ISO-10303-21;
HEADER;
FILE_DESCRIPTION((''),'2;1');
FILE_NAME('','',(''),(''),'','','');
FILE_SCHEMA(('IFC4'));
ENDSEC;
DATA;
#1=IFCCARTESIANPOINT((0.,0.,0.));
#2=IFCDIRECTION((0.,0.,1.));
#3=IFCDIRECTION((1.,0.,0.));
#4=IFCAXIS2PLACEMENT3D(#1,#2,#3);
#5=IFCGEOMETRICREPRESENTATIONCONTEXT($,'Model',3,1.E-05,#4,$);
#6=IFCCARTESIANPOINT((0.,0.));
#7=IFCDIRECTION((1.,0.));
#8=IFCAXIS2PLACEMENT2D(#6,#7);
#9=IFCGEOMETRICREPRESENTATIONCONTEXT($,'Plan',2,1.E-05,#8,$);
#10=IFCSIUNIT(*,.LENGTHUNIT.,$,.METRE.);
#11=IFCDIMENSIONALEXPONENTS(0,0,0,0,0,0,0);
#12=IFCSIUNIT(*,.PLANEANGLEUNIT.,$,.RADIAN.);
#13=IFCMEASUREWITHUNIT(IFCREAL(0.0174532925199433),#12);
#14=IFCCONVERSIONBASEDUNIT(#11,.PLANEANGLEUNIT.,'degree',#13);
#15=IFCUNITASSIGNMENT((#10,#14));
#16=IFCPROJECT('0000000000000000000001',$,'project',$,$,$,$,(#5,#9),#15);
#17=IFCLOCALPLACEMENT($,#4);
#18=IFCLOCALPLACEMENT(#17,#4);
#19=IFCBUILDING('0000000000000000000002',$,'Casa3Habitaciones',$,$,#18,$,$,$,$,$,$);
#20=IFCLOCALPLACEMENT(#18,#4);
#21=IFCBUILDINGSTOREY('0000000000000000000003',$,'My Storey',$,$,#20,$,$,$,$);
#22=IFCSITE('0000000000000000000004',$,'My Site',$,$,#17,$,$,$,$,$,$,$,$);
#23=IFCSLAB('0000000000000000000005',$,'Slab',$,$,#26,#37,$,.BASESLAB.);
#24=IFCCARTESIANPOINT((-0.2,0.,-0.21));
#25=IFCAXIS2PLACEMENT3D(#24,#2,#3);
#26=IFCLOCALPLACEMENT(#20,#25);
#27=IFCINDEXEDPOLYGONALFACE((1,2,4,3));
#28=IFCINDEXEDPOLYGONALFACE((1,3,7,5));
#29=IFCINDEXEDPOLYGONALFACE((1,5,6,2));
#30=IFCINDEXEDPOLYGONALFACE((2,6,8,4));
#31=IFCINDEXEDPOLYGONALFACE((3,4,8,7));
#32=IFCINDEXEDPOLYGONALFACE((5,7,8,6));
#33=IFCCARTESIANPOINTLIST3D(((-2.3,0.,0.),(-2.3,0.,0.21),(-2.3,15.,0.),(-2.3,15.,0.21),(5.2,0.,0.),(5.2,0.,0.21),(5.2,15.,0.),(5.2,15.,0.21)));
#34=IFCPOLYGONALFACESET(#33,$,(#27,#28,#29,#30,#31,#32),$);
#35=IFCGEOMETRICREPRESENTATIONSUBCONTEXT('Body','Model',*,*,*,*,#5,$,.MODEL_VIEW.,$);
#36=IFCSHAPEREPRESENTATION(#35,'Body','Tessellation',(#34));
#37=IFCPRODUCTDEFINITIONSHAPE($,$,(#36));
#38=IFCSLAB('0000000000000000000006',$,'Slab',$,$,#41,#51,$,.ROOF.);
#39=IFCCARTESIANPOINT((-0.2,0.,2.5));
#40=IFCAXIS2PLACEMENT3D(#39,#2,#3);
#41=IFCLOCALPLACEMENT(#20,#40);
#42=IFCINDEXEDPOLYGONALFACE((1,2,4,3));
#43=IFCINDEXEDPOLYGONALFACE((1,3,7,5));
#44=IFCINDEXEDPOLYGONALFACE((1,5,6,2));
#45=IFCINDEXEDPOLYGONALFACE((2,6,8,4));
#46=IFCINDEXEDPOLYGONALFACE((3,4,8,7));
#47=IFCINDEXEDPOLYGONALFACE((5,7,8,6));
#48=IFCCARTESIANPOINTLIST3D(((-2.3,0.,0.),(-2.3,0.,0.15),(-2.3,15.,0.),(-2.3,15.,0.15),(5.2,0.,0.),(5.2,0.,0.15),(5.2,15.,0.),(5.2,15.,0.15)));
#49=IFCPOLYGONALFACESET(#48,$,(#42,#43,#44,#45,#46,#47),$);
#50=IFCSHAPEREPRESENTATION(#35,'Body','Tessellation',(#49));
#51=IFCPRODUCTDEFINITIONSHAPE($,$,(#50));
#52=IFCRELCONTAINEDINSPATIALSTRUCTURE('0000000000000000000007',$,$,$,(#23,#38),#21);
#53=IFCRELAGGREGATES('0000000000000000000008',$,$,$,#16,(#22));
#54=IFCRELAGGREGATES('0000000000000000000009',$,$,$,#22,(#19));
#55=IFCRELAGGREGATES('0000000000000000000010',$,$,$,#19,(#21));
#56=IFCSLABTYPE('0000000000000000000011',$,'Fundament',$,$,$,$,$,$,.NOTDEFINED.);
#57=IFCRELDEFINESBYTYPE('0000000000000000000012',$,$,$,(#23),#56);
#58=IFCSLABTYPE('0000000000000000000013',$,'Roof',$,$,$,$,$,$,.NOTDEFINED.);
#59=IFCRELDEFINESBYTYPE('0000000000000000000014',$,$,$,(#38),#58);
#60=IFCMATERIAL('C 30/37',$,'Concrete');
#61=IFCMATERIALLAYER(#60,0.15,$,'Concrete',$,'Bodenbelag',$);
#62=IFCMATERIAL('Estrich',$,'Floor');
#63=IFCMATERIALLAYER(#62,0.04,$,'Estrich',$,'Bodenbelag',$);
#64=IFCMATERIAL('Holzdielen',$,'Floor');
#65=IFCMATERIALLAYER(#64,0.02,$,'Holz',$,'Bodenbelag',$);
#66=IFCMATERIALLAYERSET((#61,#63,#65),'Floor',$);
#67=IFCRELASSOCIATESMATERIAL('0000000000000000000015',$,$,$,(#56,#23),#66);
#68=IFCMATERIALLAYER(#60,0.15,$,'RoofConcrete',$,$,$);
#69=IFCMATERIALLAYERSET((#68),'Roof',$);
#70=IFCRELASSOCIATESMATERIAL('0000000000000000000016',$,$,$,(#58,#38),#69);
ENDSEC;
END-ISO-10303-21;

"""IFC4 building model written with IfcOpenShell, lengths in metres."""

from ifc_helpers import new_model, entity, si_unit, converted_unit, frame, origin_with_axes, origin_2d_with_axis, place, context, subcontext, project, spatial, line, indexed_curve, outline, extrude, material, layer, layer_set, layer_usage, type_object, element, save


model = new_model("IFC4")

# Units and contexts
model_context = context("Model", 3, precision=1e-05, world=origin_with_axes())
plan_context = context("Plan", 2, precision=1e-05, world=origin_2d_with_axis())
body_context = subcontext(model_context, "Body", "Model", "MODEL_VIEW")
ifc_project = project(units=[si_unit("LENGTHUNIT", "METRE"), converted_unit("PLANEANGLEUNIT", "degree", entity("IfcReal", 0.0174532925199433), si_unit("PLANEANGLEUNIT", "RADIAN"), dimensions=[0, 0, 0, 0, 0, 0, 0])], contexts=[model_context, plan_context])

# Site, building, storey
site_placement = place(None, origin_with_axes())
site = spatial("IfcSite", under=ifc_project, at=site_placement, Name="My Site")
building_placement = place(site_placement, origin_with_axes())
building = spatial("IfcBuilding", under=site, at=building_placement, Name="Casa3Habitaciones")
storey_placement = place(building_placement, origin_with_axes())
storey = spatial("IfcBuildingStorey", under=building, at=storey_placement, Name="My Storey")

# Slabs
ifc_material_1 = material(Name="C 30/37", Category="Concrete")
ifc_layer_1 = layer(ifc_material_1, 0.15, Name="Concrete", Category="Bodenbelag")
ifc_material_2 = material(Name="Estrich", Category="Floor")
ifc_layer_2 = layer(ifc_material_2, 0.04, Name="Estrich", Category="Bodenbelag")
ifc_material_3 = material(Name="Holzdielen", Category="Floor")
ifc_layer_3 = layer(ifc_material_3, 0.02, Name="Holz", Category="Bodenbelag")
ifc_layer_set_1 = layer_set([ifc_layer_1, ifc_layer_2, ifc_layer_3], Name="Floor")
ifc_layer_usage_1 = layer_usage(ifc_layer_set_1, "AXIS3", "POSITIVE", 0.0)
slab_type_1 = type_object("IfcSlabType", Name="Fundament", PredefinedType="NOTDEFINED", material=ifc_layer_set_1)
slab_1_placement = place(storey_placement, frame((-0.2, 0.0, -0.21), z_axis=(0.0, 0.0, 1.0), x_axis=(1.0, 0.0, 0.0)))
element("IfcSlab", 1, at=slab_1_placement, inside=storey, type_object=slab_type_1, material=ifc_layer_usage_1, Name="Slab", PredefinedType="BASESLAB", context=body_context, shape_type="SweptSolid", body=[
    extrude(outline(indexed_curve([(5.2, 15.0), (5.2, 0.0), (-2.3, 0.0), (-2.3, 15.0)], segments=[line(4, 1), line(1, 2), line(2, 3), line(3, 4)], self_intersect=False)), None, (0.0, 0.0, 1.0), 0.21),
])
ifc_layer_4 = layer(ifc_material_1, 0.15, Name="RoofConcrete")
ifc_layer_set_2 = layer_set([ifc_layer_4], Name="Roof")
ifc_layer_usage_2 = layer_usage(ifc_layer_set_2, "AXIS3", "POSITIVE", 0.0)
slab_type_2 = type_object("IfcSlabType", Name="Roof", PredefinedType="NOTDEFINED", material=ifc_layer_set_2)
slab_2_placement = place(storey_placement, frame((-0.2, 0.0, 2.5), z_axis=(0.0, 0.0, 1.0), x_axis=(1.0, 0.0, 0.0)))
element("IfcSlab", 2, at=slab_2_placement, inside=storey, type_object=slab_type_2, material=ifc_layer_usage_2, Name="Slab", PredefinedType="ROOF", context=body_context, shape_type="SweptSolid", body=[
    extrude(outline(indexed_curve([(-2.3, 15.0), (-2.3, 0.0), (5.2, 0.0), (5.2, 15.0)], segments=[line(4, 1), line(1, 2), line(2, 3), line(3, 4)], self_intersect=False)), None, (0.0, 0.0, 1.0), 0.15),
])

save(model, "model.ifc")
